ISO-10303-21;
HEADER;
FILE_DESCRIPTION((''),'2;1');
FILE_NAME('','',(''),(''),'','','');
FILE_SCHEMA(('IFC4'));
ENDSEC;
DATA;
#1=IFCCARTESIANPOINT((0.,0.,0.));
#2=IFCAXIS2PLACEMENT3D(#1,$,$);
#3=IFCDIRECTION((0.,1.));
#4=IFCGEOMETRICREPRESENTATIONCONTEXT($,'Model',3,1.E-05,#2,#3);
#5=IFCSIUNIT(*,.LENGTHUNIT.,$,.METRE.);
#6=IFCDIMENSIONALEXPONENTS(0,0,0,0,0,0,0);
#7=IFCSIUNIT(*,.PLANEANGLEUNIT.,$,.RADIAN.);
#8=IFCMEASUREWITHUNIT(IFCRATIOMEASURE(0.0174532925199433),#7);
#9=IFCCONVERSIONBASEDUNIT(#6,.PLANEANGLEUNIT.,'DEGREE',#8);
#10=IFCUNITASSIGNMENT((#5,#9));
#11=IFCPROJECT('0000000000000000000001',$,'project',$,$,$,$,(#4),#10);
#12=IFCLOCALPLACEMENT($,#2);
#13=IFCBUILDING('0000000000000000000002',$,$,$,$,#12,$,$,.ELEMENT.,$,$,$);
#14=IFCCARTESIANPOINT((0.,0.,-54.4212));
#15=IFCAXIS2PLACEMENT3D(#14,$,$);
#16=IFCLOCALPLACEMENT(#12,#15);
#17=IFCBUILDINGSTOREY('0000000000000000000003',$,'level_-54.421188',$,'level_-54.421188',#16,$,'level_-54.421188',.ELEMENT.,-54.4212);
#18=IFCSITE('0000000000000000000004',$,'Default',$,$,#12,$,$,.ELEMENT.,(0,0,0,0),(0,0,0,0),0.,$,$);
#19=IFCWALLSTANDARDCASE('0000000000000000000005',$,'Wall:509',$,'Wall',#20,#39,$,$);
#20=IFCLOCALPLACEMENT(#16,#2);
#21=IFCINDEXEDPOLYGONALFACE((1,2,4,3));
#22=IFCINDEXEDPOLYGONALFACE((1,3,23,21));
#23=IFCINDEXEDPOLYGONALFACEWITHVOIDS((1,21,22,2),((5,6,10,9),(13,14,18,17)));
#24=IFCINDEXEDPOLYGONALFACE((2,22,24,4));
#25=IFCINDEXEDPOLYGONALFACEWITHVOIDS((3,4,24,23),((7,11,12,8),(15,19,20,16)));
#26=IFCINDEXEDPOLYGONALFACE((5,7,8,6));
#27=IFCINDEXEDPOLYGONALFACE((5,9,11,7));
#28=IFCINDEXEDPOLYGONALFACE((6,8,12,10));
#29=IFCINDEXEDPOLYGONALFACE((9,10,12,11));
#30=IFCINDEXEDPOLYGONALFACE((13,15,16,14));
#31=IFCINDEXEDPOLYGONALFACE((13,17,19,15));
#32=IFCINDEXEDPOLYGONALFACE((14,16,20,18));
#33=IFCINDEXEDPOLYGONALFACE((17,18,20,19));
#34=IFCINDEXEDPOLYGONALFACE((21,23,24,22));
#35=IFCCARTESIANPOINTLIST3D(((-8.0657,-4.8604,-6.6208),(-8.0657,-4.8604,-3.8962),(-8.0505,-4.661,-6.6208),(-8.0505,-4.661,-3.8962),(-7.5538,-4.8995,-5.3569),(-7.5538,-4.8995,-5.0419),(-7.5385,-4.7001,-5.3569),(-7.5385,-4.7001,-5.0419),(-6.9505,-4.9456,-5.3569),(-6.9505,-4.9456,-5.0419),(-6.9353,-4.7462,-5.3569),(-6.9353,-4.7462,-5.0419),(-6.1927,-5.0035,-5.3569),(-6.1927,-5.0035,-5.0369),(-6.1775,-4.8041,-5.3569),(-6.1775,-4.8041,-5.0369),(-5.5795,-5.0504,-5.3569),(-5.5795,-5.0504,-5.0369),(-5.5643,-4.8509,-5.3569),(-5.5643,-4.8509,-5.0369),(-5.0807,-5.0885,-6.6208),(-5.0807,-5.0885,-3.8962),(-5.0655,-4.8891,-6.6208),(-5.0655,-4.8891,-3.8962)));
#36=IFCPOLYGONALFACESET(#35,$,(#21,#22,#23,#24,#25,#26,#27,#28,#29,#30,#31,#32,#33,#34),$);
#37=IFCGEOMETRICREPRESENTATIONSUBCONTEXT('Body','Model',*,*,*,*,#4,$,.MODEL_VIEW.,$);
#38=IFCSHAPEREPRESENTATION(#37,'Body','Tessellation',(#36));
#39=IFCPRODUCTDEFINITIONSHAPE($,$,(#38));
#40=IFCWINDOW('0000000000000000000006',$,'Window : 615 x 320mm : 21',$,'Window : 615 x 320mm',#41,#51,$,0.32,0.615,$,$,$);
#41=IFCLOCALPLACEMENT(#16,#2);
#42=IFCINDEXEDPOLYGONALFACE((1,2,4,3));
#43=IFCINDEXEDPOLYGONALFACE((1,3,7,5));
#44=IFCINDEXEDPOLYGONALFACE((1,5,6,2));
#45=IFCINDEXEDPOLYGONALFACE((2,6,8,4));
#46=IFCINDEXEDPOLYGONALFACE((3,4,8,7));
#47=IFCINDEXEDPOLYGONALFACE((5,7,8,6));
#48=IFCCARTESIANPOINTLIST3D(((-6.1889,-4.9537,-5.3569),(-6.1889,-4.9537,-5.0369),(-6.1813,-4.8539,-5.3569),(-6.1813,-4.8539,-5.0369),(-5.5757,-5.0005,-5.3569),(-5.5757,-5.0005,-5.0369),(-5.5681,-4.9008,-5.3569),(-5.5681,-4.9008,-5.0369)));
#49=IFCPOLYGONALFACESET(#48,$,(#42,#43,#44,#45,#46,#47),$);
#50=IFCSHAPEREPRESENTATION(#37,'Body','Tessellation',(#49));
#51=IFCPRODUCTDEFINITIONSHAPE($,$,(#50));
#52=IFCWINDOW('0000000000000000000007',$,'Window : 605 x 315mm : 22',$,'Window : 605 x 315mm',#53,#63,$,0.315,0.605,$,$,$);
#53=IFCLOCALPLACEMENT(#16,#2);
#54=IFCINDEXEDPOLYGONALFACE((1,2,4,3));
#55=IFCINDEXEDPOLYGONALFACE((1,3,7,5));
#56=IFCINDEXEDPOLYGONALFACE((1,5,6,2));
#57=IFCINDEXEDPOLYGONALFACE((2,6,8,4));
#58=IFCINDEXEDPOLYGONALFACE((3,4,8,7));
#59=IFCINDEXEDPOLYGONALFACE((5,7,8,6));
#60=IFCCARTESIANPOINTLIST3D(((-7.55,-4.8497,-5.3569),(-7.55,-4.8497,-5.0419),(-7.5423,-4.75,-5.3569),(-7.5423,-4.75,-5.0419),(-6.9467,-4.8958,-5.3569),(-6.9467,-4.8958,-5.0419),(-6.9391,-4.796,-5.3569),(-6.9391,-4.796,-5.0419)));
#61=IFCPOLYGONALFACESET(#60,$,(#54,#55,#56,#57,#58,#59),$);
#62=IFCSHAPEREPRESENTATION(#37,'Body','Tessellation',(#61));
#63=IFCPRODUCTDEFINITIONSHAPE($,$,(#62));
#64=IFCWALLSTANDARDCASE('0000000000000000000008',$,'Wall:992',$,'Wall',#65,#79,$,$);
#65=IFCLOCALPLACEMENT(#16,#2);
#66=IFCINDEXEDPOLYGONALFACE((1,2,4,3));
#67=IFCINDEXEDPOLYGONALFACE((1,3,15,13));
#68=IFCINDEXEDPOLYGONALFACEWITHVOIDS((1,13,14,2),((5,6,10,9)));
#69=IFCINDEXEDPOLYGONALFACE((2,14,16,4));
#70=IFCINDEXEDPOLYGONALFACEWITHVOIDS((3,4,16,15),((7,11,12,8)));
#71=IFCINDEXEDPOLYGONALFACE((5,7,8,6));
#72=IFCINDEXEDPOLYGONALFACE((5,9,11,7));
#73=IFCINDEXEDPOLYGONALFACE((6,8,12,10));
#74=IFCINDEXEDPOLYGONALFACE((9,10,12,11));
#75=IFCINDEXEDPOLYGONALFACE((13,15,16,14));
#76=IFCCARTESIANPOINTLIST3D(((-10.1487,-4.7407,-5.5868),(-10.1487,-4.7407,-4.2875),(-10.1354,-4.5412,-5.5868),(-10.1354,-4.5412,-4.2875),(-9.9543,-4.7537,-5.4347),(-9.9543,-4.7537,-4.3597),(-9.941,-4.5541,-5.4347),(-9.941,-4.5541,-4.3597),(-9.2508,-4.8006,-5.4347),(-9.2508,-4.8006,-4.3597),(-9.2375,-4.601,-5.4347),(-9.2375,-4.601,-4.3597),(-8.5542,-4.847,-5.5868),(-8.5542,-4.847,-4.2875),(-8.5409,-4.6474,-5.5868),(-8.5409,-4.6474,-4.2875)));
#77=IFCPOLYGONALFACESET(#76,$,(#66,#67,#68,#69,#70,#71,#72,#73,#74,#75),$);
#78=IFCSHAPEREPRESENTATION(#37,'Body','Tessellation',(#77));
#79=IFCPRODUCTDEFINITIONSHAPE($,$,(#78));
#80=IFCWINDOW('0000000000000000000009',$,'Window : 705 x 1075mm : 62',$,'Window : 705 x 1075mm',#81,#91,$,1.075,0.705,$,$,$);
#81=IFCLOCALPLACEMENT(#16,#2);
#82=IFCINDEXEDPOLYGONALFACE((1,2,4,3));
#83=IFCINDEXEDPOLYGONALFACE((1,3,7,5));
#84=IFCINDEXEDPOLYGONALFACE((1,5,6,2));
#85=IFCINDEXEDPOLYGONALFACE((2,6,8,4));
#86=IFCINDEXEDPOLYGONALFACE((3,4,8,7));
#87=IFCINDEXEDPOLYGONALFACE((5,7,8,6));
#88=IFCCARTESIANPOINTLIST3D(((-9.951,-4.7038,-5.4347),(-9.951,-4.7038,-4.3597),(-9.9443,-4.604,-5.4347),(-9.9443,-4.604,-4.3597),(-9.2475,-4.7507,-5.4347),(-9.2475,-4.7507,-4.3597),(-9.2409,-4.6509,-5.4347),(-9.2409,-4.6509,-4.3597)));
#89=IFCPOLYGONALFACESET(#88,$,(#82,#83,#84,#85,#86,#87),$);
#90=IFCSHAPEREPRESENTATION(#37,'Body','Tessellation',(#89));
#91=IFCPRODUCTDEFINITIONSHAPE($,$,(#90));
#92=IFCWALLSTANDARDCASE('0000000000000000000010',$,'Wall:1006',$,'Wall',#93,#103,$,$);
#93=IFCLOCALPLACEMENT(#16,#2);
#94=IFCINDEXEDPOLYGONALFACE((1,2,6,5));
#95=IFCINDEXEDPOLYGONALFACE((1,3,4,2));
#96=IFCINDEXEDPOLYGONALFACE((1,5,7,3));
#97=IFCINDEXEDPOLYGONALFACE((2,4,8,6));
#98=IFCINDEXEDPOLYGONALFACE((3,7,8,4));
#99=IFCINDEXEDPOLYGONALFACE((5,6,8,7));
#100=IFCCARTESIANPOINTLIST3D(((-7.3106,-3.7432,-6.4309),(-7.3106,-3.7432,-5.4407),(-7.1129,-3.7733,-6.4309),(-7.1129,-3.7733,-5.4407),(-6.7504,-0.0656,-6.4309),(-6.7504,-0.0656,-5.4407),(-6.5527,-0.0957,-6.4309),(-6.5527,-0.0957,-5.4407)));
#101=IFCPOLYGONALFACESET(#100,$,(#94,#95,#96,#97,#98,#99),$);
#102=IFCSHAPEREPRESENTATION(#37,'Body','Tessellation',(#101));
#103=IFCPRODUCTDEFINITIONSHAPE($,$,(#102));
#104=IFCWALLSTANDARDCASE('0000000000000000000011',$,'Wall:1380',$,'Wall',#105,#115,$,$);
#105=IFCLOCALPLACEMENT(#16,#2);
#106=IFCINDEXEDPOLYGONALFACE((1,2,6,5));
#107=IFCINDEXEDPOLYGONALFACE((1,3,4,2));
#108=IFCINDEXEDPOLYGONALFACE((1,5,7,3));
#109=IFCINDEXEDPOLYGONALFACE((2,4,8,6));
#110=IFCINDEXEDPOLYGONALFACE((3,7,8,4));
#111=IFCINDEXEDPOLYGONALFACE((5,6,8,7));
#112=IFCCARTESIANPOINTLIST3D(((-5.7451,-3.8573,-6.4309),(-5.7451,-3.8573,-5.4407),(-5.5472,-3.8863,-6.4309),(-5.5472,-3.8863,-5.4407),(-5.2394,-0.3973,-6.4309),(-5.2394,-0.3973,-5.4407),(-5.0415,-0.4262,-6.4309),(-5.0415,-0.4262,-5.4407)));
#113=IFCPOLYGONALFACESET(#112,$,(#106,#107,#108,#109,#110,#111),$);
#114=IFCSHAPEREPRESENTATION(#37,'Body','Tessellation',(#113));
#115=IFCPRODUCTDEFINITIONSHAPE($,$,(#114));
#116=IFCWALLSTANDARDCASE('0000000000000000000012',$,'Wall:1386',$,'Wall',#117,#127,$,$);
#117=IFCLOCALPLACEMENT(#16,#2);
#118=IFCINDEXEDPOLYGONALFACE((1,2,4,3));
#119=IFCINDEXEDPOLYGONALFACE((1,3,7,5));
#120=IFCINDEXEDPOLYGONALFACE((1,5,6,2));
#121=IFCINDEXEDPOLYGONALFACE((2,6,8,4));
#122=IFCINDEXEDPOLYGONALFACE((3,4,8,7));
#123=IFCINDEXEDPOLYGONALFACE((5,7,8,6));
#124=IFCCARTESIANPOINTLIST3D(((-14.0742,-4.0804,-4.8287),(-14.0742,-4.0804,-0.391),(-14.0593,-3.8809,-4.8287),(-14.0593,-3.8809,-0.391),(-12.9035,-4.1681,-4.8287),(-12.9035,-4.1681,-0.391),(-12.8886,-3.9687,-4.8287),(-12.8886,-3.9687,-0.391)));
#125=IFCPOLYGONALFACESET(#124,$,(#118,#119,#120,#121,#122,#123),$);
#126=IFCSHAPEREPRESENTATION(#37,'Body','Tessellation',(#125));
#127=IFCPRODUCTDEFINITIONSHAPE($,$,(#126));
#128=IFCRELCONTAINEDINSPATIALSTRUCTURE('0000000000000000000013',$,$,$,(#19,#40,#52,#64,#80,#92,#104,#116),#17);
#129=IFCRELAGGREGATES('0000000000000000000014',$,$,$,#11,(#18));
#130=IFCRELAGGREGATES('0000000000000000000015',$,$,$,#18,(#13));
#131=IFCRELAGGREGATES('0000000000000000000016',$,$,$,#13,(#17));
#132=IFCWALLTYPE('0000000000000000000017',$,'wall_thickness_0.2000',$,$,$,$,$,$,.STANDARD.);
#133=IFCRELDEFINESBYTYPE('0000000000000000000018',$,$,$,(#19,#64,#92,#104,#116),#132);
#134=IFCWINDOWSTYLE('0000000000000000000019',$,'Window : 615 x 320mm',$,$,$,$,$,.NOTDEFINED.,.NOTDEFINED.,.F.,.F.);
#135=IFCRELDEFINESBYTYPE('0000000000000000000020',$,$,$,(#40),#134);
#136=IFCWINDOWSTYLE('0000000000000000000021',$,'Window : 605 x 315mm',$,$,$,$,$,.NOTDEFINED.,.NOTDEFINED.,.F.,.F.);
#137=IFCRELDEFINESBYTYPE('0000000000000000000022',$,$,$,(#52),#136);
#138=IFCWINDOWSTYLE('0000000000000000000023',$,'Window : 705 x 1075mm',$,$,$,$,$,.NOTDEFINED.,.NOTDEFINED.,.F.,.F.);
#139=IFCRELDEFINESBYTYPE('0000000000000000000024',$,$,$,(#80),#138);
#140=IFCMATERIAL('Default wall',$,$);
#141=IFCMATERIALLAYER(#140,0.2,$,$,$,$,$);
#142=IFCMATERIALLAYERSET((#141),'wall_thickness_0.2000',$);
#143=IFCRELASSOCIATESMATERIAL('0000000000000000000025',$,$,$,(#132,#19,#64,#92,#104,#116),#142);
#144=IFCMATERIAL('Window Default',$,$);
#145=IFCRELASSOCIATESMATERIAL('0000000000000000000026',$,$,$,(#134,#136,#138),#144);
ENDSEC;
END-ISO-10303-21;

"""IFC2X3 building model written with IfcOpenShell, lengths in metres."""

from ifc_helpers import new_model, entity, si_unit, converted_unit, direction, frame, frame_2d, origin, origin_2d_with_axis, place, context, subcontext, project, spatial, polyline, rectangle, outline, extrude, source, transform, mapped, material, layer, layer_set, layer_usage, type_object, type_shapes, element, fill, save


model = new_model("IFC2X3")

# Units and contexts
model_context = context("Model", 3, precision=1e-05, world=origin(), true_north=direction((0.0, 1.0)))
body_context = subcontext(model_context, "Body", "Model", "MODEL_VIEW")
ifc_project = project(units=[si_unit("LENGTHUNIT", "METRE"), converted_unit("PLANEANGLEUNIT", "DEGREE", entity("IfcRatioMeasure", 0.0174532925199433), si_unit("PLANEANGLEUNIT", "RADIAN"), dimensions=[0, 0, 0, 0, 0, 0, 0])], contexts=[model_context])

# Site, building, storey
placement_1 = place(None, origin())
site = spatial("IfcSite", under=ifc_project, at=placement_1, Name="Default", CompositionType="ELEMENT", RefLatitude=(0, 0, 0, 0), RefLongitude=(0, 0, 0, 0), RefElevation=0.0)
building = spatial("IfcBuilding", under=site, at=placement_1, CompositionType="ELEMENT")
storey_placement = place(placement_1, frame((0.0, 0.0, -54.4212)))
storey = spatial("IfcBuildingStorey", under=building, at=storey_placement, Name="level_-54.421188", ObjectType="level_-54.421188", LongName="level_-54.421188", CompositionType="ELEMENT", Elevation=-54.4212)

# Wall, openings, windows
ifc_material_1 = material(Name="Default wall")
ifc_layer = layer(ifc_material_1, 0.2)
ifc_layer_set = layer_set([ifc_layer], Name="wall_thickness_0.2000")
ifc_layer_usage = layer_usage(ifc_layer_set, "AXIS2", "POSITIVE", -0.1)
wall_type = type_object("IfcWallType", Name="wall_thickness_0.2000", PredefinedType="STANDARD", material=ifc_layer_set)
placement_2 = place(placement_1, frame((0.0, 0.0, -61.042)))
wall_1_placement = place(placement_2, frame((-5.0731, -4.9888, 0.0), z_axis=(0.0, 0.0, 1.0), x_axis=(-0.997094, 0.076183, 0.0)))
wall_1 = element("IfcWallStandardCase", 1, at=wall_1_placement, inside=storey, type_object=wall_type, material=ifc_layer_usage, Name="Wall:509", ObjectType="Wall", context=body_context, shape_type="SweptSolid", body=[
    extrude(outline(polyline([(2.9937, -0.1), (2.9937, 0.1), (0.0, 0.1), (0.0, -0.1), (2.9937, -0.1)])), origin(), (0.0, 0.0, 1.0), 2.7247),
])
opening_1_placement = place(wall_1_placement, frame((0.5003, -0.1, 1.264)))
opening_1 = element("IfcOpeningElement", 2, at=opening_1_placement, cuts=wall_1, ObjectType="Opening", context=body_context, shape_type="SweptSolid", body=[
    extrude(rectangle(XDim=0.615, YDim=0.32, at=frame_2d((0.16, 0.3075), x_axis=(0.0, 1.0))), frame((0.0, 0.0, 0.0), z_axis=(0.0, 1.0, 0.0), x_axis=(0.0, 0.0, 1.0)), (0.0, 0.0, 1.0), 0.2),
])
opening_2_placement = place(wall_1_placement, frame((1.8753, -0.1, 1.264)))
opening_2 = element("IfcOpeningElement", 3, at=opening_2_placement, cuts=wall_1, ObjectType="Opening", context=body_context, shape_type="SweptSolid", body=[
    extrude(rectangle(XDim=0.605, YDim=0.315, at=frame_2d((0.1575, 0.3025), x_axis=(0.0, 1.0))), frame((0.0, 0.0, 0.0), z_axis=(0.0, 1.0, 0.0), x_axis=(0.0, 0.0, 1.0)), (0.0, 0.0, 1.0), 0.2),
])
ifc_material_2 = material(Name="Window Default")
window_style_1 = type_object("IfcWindowStyle", Name="Window : 615 x 320mm", ConstructionType="NOTDEFINED", OperationType="NOTDEFINED", ParameterTakesPrecedence=False, Sizeable=False, material=ifc_material_2)
shared_shape_1 = source(origin(), body_context, "Body", "SweptSolid", [
    extrude(rectangle(XDim=0.1, YDim=0.615, at=origin_2d_with_axis()), frame((0.3075, 0.1, 0.0), z_axis=(0.0, 0.0, 1.0), x_axis=(0.0, 1.0, 0.0)), (0.0, 0.0, 1.0), 0.32),
])
type_shapes(window_style_1, [shared_shape_1])
window_1_placement = place(opening_1_placement, origin())
window_1 = element("IfcWindow", 4, at=window_1_placement, inside=storey, type_object=window_style_1, Name="Window : 615 x 320mm : 21", ObjectType="Window : 615 x 320mm", OverallHeight=0.32, OverallWidth=0.615, context=body_context, shape_type="MappedRepresentation", body=[
    mapped(shared_shape_1, transform((0.0, 0.0, 0.0), scale=1.0)),
])
fill(opening_1, window_1)
window_style_2 = type_object("IfcWindowStyle", Name="Window : 605 x 315mm", ConstructionType="NOTDEFINED", OperationType="NOTDEFINED", ParameterTakesPrecedence=False, Sizeable=False, material=ifc_material_2)
shared_shape_2 = source(origin(), body_context, "Body", "SweptSolid", [
    extrude(rectangle(XDim=0.1, YDim=0.605, at=origin_2d_with_axis()), frame((0.3025, 0.1, 0.0), z_axis=(0.0, 0.0, 1.0), x_axis=(0.0, 1.0, 0.0)), (0.0, 0.0, 1.0), 0.315),
])
type_shapes(window_style_2, [shared_shape_2])
window_2_placement = place(opening_2_placement, origin())
window_2 = element("IfcWindow", 5, at=window_2_placement, inside=storey, type_object=window_style_2, Name="Window : 605 x 315mm : 22", ObjectType="Window : 605 x 315mm", OverallHeight=0.315, OverallWidth=0.605, context=body_context, shape_type="MappedRepresentation", body=[
    mapped(shared_shape_2, transform((0.0, 0.0, 0.0), scale=1.0)),
])
fill(opening_2, window_2)

# Wall, opening, window
placement_3 = place(placement_1, frame((0.0, 0.0, -60.008)))
wall_2_placement = place(placement_3, frame((-8.5475, -4.7472, 0.0), z_axis=(0.0, 0.0, 1.0), x_axis=(-0.997787, 0.066499, 0.0)))
wall_2 = element("IfcWallStandardCase", 6, at=wall_2_placement, inside=storey, type_object=wall_type, material=ifc_layer_usage, Name="Wall:992", ObjectType="Wall", context=body_context, shape_type="SweptSolid", body=[
    extrude(outline(polyline([(1.5981, -0.1), (1.5981, 0.1), (0.0, 0.1), (0.0, -0.1), (1.5981, -0.1)])), origin(), (0.0, 0.0, 1.0), 1.2994),
])
opening_3_placement = place(wall_2_placement, frame((0.6982, -0.1, 0.1521)))
opening_3 = element("IfcOpeningElement", 7, at=opening_3_placement, cuts=wall_2, ObjectType="Opening", context=body_context, shape_type="SweptSolid", body=[
    extrude(rectangle(XDim=0.705, YDim=1.075, at=frame_2d((0.5375, 0.3525), x_axis=(0.0, 1.0))), frame((0.0, 0.0, 0.0), z_axis=(0.0, 1.0, 0.0), x_axis=(0.0, 0.0, 1.0)), (0.0, 0.0, 1.0), 0.2),
])
window_style_3 = type_object("IfcWindowStyle", Name="Window : 705 x 1075mm", ConstructionType="NOTDEFINED", OperationType="NOTDEFINED", ParameterTakesPrecedence=False, Sizeable=False, material=ifc_material_2)
shared_shape_3 = source(origin(), body_context, "Body", "SweptSolid", [
    extrude(rectangle(XDim=0.1, YDim=0.705, at=origin_2d_with_axis()), frame((0.3525, 0.1, 0.0), z_axis=(0.0, 0.0, 1.0), x_axis=(0.0, 1.0, 0.0)), (0.0, 0.0, 1.0), 1.075),
])
type_shapes(window_style_3, [shared_shape_3])
window_3_placement = place(opening_3_placement, origin())
window_3 = element("IfcWindow", 8, at=window_3_placement, inside=storey, type_object=window_style_3, Name="Window : 705 x 1075mm : 62", ObjectType="Window : 705 x 1075mm", OverallHeight=1.075, OverallWidth=0.705, context=body_context, shape_type="MappedRepresentation", body=[
    mapped(shared_shape_3, transform((0.0, 0.0, 0.0), scale=1.0)),
])
fill(opening_3, window_3)

# Wall
placement_4 = place(placement_1, frame((0.0, 0.0, -60.8521)))
wall_3_placement = place(placement_4, frame((-7.2118, -3.7582, 0.0), z_axis=(0.0, 0.0, 1.0), x_axis=(0.150589, 0.988596, 0.0)))
element("IfcWallStandardCase", 9, at=wall_3_placement, inside=storey, type_object=wall_type, material=ifc_layer_usage, Name="Wall:1006", ObjectType="Wall", context=body_context, shape_type="SweptSolid", body=[
    extrude(outline(polyline([(3.72, -0.1), (3.72, 0.1), (0.0, 0.1), (0.0, -0.1), (3.72, -0.1)])), origin(), (0.0, 0.0, 1.0), 0.9901),
])

# Walls
placement_5 = place(placement_1, frame((0.0, 0.0, -60.8521)))
wall_4_placement = place(placement_5, frame((-5.6462, -3.8718, 0.0), z_axis=(0.0, 0.0, 1.0), x_axis=(0.144628, 0.989486, 0.0)))
element("IfcWallStandardCase", 10, at=wall_4_placement, inside=storey, type_object=wall_type, material=ifc_layer_usage, Name="Wall:1380", ObjectType="Wall", context=body_context, shape_type="SweptSolid", body=[
    extrude(outline(polyline([(3.4968, -0.1), (3.4968, 0.1), (0.0, 0.1), (0.0, -0.1), (3.4968, -0.1)])), origin(), (0.0, 0.0, 1.0), 0.9901),
])
placement_6 = place(placement_1, frame((0.0, 0.0, -59.2499)))
wall_5_placement = place(placement_6, frame((-12.8961, -4.0684, 0.0), z_axis=(0.0, 0.0, 1.0), x_axis=(-0.997204, 0.074721, 0.0)))
element("IfcWallStandardCase", 11, at=wall_5_placement, inside=storey, type_object=wall_type, material=ifc_layer_usage, Name="Wall:1386", ObjectType="Wall", context=body_context, shape_type="SweptSolid", body=[
    extrude(outline(polyline([(1.174, -0.1), (1.174, 0.1), (0.0, 0.1), (0.0, -0.1), (1.174, -0.1)])), origin(), (0.0, 0.0, 1.0), 4.4377),
])

save(model, "model.ifc")
